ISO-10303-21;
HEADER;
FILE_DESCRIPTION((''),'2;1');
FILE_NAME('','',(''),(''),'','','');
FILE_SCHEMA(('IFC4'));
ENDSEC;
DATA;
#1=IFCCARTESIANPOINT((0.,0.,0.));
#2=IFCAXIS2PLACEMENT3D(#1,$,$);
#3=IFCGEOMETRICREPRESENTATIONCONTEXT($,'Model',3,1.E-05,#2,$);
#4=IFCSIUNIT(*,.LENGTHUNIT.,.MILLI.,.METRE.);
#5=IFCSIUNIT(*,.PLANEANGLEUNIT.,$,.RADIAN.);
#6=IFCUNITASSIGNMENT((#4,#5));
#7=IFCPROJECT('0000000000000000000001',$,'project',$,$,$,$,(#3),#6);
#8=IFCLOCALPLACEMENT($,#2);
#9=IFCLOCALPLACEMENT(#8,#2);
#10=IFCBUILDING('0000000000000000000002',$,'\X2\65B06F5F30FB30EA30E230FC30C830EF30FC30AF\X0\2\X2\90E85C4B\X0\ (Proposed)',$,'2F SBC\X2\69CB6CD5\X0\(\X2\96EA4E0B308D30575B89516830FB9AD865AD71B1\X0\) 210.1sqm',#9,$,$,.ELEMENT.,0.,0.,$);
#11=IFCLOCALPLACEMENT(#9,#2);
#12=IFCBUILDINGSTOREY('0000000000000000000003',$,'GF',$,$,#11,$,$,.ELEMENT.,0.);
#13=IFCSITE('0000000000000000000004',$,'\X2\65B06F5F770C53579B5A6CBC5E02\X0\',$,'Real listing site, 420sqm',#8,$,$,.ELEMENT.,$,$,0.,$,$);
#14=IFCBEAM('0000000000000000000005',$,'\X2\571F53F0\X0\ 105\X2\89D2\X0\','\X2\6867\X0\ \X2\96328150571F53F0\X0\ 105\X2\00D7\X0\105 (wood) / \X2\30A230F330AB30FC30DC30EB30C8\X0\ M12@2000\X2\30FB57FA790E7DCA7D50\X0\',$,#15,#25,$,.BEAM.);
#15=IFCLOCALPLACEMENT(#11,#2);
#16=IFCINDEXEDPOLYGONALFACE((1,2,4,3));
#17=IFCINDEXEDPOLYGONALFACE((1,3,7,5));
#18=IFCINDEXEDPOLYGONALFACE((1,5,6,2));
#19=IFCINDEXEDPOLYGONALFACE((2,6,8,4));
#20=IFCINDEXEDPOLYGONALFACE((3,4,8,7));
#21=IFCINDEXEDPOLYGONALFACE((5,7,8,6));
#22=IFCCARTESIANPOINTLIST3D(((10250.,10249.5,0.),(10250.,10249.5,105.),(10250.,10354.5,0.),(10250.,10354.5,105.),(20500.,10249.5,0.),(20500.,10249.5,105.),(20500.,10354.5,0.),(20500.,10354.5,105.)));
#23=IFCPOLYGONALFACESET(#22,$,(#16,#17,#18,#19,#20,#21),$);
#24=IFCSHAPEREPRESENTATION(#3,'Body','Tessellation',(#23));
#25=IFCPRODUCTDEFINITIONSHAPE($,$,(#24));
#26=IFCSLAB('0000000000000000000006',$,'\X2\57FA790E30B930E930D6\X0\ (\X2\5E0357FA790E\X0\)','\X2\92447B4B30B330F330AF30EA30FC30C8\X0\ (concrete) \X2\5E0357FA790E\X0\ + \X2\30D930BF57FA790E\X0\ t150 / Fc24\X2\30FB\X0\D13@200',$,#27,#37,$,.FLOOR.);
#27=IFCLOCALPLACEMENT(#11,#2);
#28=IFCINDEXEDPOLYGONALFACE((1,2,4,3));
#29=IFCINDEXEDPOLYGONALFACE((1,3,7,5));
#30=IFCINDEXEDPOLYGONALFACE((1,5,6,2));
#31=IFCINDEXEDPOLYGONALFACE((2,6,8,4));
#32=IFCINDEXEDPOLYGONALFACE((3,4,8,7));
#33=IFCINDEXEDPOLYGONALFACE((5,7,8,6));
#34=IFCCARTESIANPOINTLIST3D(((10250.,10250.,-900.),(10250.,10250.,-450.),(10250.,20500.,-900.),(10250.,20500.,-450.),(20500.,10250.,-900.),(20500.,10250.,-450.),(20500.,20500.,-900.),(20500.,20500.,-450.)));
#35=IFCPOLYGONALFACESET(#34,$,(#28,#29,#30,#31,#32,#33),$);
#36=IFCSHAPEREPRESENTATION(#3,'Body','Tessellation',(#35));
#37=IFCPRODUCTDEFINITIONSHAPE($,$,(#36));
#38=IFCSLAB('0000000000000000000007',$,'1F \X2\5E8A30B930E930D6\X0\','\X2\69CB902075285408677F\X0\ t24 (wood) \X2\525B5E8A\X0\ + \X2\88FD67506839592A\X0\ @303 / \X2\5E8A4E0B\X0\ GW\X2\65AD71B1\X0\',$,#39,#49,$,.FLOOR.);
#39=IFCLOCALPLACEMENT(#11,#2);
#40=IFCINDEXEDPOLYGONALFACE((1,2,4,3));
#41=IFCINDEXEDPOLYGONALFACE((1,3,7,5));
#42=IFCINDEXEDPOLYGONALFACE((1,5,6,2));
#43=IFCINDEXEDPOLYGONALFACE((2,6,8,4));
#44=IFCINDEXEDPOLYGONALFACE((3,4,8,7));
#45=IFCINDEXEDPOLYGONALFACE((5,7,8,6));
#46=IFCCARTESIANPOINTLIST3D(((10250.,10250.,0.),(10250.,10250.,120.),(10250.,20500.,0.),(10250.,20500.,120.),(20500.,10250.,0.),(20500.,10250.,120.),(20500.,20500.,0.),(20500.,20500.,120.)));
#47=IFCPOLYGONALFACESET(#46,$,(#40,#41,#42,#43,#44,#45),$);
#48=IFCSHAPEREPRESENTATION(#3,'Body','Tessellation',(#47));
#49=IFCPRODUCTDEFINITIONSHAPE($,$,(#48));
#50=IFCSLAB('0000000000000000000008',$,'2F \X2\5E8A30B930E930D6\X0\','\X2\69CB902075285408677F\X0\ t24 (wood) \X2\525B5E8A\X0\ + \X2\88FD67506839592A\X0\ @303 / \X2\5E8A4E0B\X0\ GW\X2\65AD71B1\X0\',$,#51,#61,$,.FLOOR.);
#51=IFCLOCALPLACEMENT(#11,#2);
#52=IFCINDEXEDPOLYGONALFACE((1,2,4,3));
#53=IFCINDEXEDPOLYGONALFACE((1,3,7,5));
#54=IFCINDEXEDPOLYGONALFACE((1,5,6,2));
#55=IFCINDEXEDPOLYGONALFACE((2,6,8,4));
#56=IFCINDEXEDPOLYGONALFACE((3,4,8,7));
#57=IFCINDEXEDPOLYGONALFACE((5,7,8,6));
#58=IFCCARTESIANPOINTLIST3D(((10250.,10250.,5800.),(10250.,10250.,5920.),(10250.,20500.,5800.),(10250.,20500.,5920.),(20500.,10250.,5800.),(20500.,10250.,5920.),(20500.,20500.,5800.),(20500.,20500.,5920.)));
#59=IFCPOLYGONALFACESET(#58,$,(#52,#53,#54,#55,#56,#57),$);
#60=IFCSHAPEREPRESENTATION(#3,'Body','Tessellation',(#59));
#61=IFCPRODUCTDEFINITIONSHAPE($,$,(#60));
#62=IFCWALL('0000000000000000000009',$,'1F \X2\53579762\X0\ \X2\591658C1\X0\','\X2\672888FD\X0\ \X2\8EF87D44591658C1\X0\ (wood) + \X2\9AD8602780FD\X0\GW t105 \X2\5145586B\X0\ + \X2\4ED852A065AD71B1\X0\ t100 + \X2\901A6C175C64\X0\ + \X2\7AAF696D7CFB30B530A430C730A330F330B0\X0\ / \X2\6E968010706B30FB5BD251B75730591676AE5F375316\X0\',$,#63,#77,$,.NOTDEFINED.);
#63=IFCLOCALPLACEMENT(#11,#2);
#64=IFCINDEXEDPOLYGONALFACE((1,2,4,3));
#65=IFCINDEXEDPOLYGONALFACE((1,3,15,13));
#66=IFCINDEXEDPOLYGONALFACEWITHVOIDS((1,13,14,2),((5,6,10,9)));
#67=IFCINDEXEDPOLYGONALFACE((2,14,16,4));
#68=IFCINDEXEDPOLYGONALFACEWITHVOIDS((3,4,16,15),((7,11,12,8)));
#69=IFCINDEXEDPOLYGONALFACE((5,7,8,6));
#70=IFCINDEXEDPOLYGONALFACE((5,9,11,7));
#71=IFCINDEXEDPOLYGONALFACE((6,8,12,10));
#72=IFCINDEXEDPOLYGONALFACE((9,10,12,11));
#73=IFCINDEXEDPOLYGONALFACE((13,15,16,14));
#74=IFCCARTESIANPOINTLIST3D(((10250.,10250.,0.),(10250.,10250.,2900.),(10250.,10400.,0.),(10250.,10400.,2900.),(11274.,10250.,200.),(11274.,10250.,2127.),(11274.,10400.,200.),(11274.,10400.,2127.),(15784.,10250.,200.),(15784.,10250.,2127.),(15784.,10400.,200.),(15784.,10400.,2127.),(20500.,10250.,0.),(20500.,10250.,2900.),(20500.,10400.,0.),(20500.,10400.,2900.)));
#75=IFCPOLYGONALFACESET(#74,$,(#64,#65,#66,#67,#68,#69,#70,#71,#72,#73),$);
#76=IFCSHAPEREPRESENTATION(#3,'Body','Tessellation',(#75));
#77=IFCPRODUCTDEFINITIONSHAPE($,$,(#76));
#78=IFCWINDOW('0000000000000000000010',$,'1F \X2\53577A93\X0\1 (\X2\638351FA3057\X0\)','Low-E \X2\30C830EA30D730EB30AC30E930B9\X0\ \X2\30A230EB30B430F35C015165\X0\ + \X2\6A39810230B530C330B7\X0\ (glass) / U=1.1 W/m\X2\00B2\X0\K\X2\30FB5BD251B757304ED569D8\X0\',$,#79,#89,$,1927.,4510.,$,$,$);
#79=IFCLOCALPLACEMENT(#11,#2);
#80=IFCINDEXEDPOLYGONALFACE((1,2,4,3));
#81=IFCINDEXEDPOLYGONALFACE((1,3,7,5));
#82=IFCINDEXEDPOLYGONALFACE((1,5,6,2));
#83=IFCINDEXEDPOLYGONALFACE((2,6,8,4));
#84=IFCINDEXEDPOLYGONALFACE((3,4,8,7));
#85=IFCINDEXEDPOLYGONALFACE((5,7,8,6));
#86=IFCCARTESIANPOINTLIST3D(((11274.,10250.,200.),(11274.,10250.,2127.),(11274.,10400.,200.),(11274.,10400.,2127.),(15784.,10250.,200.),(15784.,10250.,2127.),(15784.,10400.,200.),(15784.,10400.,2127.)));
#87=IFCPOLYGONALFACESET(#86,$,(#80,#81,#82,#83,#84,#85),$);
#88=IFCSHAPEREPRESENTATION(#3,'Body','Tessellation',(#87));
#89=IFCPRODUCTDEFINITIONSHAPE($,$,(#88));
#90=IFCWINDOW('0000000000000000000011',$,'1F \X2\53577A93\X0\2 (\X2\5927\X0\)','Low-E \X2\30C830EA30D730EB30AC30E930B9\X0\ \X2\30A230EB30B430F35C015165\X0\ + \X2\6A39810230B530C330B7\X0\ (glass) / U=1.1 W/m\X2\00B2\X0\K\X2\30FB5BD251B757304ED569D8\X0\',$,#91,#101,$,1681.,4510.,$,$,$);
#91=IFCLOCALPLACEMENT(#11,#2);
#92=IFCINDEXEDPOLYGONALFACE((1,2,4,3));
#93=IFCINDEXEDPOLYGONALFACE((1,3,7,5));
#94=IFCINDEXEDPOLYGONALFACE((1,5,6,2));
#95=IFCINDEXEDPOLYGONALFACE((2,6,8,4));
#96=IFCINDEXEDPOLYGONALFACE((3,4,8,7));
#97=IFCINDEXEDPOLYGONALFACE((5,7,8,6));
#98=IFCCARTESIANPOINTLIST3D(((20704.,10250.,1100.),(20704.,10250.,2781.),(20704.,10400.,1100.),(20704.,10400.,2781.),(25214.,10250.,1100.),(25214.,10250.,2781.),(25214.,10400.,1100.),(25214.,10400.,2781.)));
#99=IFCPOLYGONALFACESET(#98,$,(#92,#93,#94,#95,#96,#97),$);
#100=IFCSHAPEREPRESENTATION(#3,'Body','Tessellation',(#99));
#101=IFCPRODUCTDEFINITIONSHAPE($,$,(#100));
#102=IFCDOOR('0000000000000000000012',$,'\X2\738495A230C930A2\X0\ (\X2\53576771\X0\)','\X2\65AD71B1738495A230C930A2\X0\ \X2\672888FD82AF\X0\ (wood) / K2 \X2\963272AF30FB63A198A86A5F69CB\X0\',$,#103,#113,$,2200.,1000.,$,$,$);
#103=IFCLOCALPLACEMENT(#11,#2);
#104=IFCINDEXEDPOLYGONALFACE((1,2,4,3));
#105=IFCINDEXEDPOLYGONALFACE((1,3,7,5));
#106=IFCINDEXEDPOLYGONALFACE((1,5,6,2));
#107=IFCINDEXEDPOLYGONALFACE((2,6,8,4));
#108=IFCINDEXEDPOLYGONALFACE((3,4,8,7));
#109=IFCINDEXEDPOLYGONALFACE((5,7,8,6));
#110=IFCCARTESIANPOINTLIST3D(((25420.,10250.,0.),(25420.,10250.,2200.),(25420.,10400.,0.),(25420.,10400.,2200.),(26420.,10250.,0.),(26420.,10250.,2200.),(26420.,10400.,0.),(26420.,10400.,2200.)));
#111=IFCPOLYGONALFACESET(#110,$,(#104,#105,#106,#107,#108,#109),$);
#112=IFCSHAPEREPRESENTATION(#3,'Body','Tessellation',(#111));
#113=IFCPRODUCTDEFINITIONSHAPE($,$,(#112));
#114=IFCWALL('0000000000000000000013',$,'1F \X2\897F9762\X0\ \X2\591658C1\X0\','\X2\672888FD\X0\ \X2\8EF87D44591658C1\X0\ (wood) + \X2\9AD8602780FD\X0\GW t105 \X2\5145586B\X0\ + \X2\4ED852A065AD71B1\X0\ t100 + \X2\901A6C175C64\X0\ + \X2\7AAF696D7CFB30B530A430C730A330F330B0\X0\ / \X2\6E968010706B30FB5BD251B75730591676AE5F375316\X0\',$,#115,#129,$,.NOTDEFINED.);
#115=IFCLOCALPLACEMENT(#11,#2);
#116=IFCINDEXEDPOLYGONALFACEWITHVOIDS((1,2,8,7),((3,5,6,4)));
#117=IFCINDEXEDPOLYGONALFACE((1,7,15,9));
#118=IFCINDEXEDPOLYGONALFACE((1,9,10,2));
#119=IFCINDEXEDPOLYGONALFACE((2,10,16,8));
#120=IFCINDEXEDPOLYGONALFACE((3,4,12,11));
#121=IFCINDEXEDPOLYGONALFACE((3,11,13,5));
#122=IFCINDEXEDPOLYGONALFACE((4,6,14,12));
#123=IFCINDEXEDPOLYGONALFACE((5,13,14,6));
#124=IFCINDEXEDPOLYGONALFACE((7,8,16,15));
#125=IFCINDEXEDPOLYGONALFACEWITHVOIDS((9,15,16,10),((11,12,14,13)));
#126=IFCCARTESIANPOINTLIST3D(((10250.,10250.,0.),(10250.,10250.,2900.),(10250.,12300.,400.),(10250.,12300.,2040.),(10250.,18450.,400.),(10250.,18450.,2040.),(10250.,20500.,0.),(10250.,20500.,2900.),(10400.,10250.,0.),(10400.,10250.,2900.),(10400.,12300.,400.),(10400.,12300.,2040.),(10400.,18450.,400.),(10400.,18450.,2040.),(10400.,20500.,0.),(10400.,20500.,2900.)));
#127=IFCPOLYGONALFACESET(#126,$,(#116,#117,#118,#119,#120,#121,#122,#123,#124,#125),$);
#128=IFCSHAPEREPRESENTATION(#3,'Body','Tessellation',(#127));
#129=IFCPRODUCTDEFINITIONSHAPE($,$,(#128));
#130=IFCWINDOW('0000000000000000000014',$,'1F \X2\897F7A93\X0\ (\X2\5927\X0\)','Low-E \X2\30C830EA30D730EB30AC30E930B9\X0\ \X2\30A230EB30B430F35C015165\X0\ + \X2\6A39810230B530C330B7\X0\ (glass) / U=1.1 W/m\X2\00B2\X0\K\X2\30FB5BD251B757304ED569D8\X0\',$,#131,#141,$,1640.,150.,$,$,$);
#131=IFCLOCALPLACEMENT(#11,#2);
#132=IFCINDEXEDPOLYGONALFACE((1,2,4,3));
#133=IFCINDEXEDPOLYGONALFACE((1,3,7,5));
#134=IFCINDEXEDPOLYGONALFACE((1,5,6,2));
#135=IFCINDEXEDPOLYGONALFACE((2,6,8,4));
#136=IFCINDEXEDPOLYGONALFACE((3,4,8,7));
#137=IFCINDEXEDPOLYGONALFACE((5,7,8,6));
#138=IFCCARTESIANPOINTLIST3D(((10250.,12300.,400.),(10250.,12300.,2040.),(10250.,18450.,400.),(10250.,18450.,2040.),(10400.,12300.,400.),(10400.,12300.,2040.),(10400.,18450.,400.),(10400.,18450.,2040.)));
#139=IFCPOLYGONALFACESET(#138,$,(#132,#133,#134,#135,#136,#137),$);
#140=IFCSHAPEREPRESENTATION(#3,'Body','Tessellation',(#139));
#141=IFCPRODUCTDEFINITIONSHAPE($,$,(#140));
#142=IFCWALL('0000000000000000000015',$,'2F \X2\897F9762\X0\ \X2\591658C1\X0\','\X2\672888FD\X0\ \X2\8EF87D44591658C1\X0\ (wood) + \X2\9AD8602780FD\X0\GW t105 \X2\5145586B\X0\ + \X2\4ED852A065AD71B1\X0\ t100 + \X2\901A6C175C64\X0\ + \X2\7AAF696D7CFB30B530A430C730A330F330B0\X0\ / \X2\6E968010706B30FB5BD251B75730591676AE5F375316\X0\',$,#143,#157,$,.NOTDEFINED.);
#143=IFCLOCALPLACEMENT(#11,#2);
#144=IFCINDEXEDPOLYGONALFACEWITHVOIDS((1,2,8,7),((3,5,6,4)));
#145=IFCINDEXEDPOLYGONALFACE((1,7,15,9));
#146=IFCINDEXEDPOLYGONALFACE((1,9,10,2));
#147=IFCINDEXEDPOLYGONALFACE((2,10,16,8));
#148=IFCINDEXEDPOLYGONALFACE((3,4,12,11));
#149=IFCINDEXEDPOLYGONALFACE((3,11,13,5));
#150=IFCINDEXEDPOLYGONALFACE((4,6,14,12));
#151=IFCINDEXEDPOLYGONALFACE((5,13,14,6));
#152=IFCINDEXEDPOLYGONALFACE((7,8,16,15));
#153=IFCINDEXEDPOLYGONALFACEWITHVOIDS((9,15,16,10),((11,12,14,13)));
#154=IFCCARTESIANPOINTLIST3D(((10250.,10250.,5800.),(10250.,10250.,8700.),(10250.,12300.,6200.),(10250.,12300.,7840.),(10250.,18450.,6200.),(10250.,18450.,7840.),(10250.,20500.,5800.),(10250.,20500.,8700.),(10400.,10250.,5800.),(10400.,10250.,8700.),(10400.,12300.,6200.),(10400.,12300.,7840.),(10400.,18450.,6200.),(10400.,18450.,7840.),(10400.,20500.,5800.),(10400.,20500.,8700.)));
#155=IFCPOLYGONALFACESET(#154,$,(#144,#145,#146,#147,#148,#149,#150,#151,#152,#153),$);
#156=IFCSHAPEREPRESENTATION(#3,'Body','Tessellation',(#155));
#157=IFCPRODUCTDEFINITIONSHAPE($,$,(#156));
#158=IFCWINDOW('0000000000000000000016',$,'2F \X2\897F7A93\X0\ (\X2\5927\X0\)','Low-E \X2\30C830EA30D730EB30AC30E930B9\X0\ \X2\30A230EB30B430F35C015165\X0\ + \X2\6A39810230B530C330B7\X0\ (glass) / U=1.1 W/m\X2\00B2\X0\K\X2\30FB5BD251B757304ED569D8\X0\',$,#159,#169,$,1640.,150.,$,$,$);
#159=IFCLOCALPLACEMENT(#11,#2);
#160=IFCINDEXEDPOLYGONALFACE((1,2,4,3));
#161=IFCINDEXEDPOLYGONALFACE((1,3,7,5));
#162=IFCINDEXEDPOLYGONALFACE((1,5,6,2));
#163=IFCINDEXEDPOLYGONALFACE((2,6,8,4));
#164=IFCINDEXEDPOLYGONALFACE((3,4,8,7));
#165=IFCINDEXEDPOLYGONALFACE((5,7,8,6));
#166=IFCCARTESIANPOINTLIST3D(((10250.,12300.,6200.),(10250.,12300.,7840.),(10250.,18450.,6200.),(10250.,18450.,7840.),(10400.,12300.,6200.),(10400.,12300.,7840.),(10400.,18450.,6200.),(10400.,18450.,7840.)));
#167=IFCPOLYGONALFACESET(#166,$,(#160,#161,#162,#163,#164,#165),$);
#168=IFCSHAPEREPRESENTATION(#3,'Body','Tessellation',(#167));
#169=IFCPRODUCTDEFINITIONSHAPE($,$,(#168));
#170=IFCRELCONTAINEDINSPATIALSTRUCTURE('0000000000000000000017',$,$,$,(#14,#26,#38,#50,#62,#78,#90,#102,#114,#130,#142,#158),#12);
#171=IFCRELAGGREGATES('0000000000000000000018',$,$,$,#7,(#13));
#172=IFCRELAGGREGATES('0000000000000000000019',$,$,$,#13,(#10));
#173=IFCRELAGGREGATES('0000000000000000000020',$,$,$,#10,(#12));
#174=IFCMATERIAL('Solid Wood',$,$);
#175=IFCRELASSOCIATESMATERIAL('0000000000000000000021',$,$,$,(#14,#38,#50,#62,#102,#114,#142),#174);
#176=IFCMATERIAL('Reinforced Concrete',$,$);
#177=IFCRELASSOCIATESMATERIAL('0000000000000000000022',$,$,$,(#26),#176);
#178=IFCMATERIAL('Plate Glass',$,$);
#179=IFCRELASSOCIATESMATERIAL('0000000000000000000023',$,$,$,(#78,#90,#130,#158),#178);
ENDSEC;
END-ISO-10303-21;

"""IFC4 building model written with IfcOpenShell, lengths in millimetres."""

from ifc_helpers import new_model, si_unit, frame, frame_2d, origin, place, context, project, spatial, rectangle, extrude, material, element, fill, save


model = new_model("IFC4")

# Units and contexts
model_context = context("Model", 3, precision=1e-05, world=origin())
ifc_project = project(units=[si_unit("LENGTHUNIT", "METRE", prefix="MILLI"), si_unit("PLANEANGLEUNIT", "RADIAN")], contexts=[model_context])

# Site, building, storey
site_placement = place(None, origin())
site = spatial("IfcSite", under=ifc_project, at=site_placement, Name="新潟県南魚沼市", ObjectType="Real listing site, 420sqm", CompositionType="ELEMENT", RefElevation=0.0)
building_placement = place(site_placement, origin())
building = spatial("IfcBuilding", under=site, at=building_placement, Name="新潟・リモートワーク2部屋 (Proposed)", ObjectType="2F SBC構法(雪下ろし安全・高断熱) 210.1sqm", CompositionType="ELEMENT", ElevationOfRefHeight=0.0, ElevationOfTerrain=0.0)
storey_placement = place(building_placement, origin())
storey = spatial("IfcBuildingStorey", under=building, at=storey_placement, Name="GF", CompositionType="ELEMENT", Elevation=0.0)

# Shared definitions
ifc_material_1 = material(Name="Solid Wood")

# Beam
beam_placement = place(storey_placement, frame((5125.0, 5125.0, 0.0)))
element("IfcBeam", 1, at=beam_placement, inside=storey, material=ifc_material_1, Name="土台 105角", Description="桧 防腐土台 105×105 (wood) / アンカーボルト M12@2000・基礎緊結", PredefinedType="BEAM", context=model_context, shape_type="SweptSolid", body=[
    extrude(rectangle(XDim=10250.0, YDim=105.0, at=frame_2d((5125.0, 52.0))), frame((5125.0, 5125.0, 0.0)), (0.0, 0.0, 1.0), 105.0),
])

# Slabs
ifc_material_2 = material(Name="Reinforced Concrete")
slab_1_placement = place(storey_placement, frame((5125.0, 5125.0, -450.0)))
element("IfcSlab", 2, at=slab_1_placement, inside=storey, material=ifc_material_2, Name="基礎スラブ (布基礎)", Description="鉄筋コンクリート (concrete) 布基礎 + ベタ基礎 t150 / Fc24・D13@200", PredefinedType="FLOOR", context=model_context, shape_type="SweptSolid", body=[
    extrude(rectangle(XDim=10250.0, YDim=10250.0, at=frame_2d((5125.0, 5125.0))), frame((5125.0, 5125.0, -450.0)), (0.0, 0.0, 1.0), 450.0),
])
slab_2_placement = place(storey_placement, frame((5125.0, 5125.0, 0.0)))
element("IfcSlab", 3, at=slab_2_placement, inside=storey, material=ifc_material_1, Name="1F 床スラブ", Description="構造用合板 t24 (wood) 剛床 + 製材根太 @303 / 床下 GW断熱", PredefinedType="FLOOR", context=model_context, shape_type="SweptSolid", body=[
    extrude(rectangle(XDim=10250.0, YDim=10250.0, at=frame_2d((5125.0, 5125.0))), frame((5125.0, 5125.0, 0.0)), (0.0, 0.0, 1.0), 120.0),
])
slab_3_placement = place(storey_placement, frame((5125.0, 5125.0, 2900.0)))
element("IfcSlab", 4, at=slab_3_placement, inside=storey, material=ifc_material_1, Name="2F 床スラブ", Description="構造用合板 t24 (wood) 剛床 + 製材根太 @303 / 床下 GW断熱", PredefinedType="FLOOR", context=model_context, shape_type="SweptSolid", body=[
    extrude(rectangle(XDim=10250.0, YDim=10250.0, at=frame_2d((5125.0, 5125.0))), frame((5125.0, 5125.0, 2900.0)), (0.0, 0.0, 1.0), 120.0),
])

# Wall, openings, windows, door
wall_1_placement = place(storey_placement, frame((5125.0, 5125.0, 0.0)))
wall_1 = element("IfcWall", 5, at=wall_1_placement, inside=storey, material=ifc_material_1, Name="1F 南面 外壁", Description="木製 軸組外壁 (wood) + 高性能GW t105 充填 + 付加断熱 t100 + 通気層 + 窯業系サイディング / 準耐火・寒冷地外皮強化", PredefinedType="NOTDEFINED", context=model_context, shape_type="SweptSolid", body=[
    extrude(rectangle(XDim=10250.0, YDim=150.0, at=frame_2d((5125.0, 75.0))), frame((5125.0, 5125.0, 0.0)), (0.0, 0.0, 1.0), 2900.0),
])
opening_1_placement = place(storey_placement, frame((5637.0, 5125.0, 100.0)))
opening_1 = element("IfcOpeningElement", 6, at=opening_1_placement, cuts=wall_1, PredefinedType="NOTDEFINED", context=model_context, shape_type="SweptSolid", body=[
    extrude(rectangle(XDim=4510.0, YDim=150.0, at=frame_2d((2255.0, 75.0))), frame((5637.0, 5125.0, 100.0)), (0.0, 0.0, 1.0), 1927.0),
])
opening_2_placement = place(storey_placement, frame((10352.0, 5125.0, 550.0)))
opening_2 = element("IfcOpeningElement", 7, at=opening_2_placement, cuts=wall_1, PredefinedType="NOTDEFINED", context=model_context, shape_type="SweptSolid", body=[
    extrude(rectangle(XDim=4510.0, YDim=150.0, at=frame_2d((2255.0, 75.0))), frame((10352.0, 5125.0, 550.0)), (0.0, 0.0, 1.0), 1681.0),
])
opening_3_placement = place(storey_placement, frame((12710.0, 5125.0, 0.0)))
opening_3 = element("IfcOpeningElement", 8, at=opening_3_placement, cuts=wall_1, PredefinedType="NOTDEFINED", context=model_context, shape_type="SweptSolid", body=[
    extrude(rectangle(XDim=1000.0, YDim=150.0, at=frame_2d((500.0, 75.0))), frame((12710.0, 5125.0, 0.0)), (0.0, 0.0, 1.0), 2200.0),
])
ifc_material_3 = material(Name="Plate Glass")
window_1_placement = place(storey_placement, frame((5637.0, 5125.0, 100.0)))
window_1 = element("IfcWindow", 9, at=window_1_placement, inside=storey, material=ifc_material_3, Name="1F 南窓1 (掃出し)", Description="Low-E トリプルガラス アルゴン封入 + 樹脂サッシ (glass) / U=1.1 W/m²K・寒冷地仕様", OverallHeight=1927.0, OverallWidth=4510.0, context=model_context, shape_type="SweptSolid", body=[
    extrude(rectangle(XDim=4510.0, YDim=150.0, at=frame_2d((2255.0, 75.0))), frame((5637.0, 5125.0, 100.0)), (0.0, 0.0, 1.0), 1927.0),
])
fill(opening_1, window_1)
window_2_placement = place(storey_placement, frame((10352.0, 5125.0, 550.0)))
window_2 = element("IfcWindow", 10, at=window_2_placement, inside=storey, material=ifc_material_3, Name="1F 南窓2 (大)", Description="Low-E トリプルガラス アルゴン封入 + 樹脂サッシ (glass) / U=1.1 W/m²K・寒冷地仕様", OverallHeight=1681.0, OverallWidth=4510.0, context=model_context, shape_type="SweptSolid", body=[
    extrude(rectangle(XDim=4510.0, YDim=150.0, at=frame_2d((2255.0, 75.0))), frame((10352.0, 5125.0, 550.0)), (0.0, 0.0, 1.0), 1681.0),
])
fill(opening_2, window_2)
door_placement = place(storey_placement, frame((12710.0, 5125.0, 0.0)))
door = element("IfcDoor", 11, at=door_placement, inside=storey, material=ifc_material_1, Name="玄関ドア (南東)", Description="断熱玄関ドア 木製芯 (wood) / K2 防犯・採風機構", OverallHeight=2200.0, OverallWidth=1000.0, context=model_context, shape_type="SweptSolid", body=[
    extrude(rectangle(XDim=1000.0, YDim=150.0, at=frame_2d((500.0, 75.0))), frame((12710.0, 5125.0, 0.0)), (0.0, 0.0, 1.0), 2200.0),
])
fill(opening_3, door)

# Wall, opening, window
wall_2_placement = place(storey_placement, frame((5125.0, 5125.0, 0.0)))
wall_2 = element("IfcWall", 12, at=wall_2_placement, inside=storey, material=ifc_material_1, Name="1F 西面 外壁", Description="木製 軸組外壁 (wood) + 高性能GW t105 充填 + 付加断熱 t100 + 通気層 + 窯業系サイディング / 準耐火・寒冷地外皮強化", PredefinedType="NOTDEFINED", context=model_context, shape_type="SweptSolid", body=[
    extrude(rectangle(XDim=150.0, YDim=10250.0, at=frame_2d((75.0, 5125.0))), frame((5125.0, 5125.0, 0.0)), (0.0, 0.0, 1.0), 2900.0),
])
opening_4_placement = place(storey_placement, frame((5125.0, 6150.0, 200.0)))
opening_4 = element("IfcOpeningElement", 13, at=opening_4_placement, cuts=wall_2, PredefinedType="NOTDEFINED", context=model_context, shape_type="SweptSolid", body=[
    extrude(rectangle(XDim=150.0, YDim=6150.0, at=frame_2d((75.0, 3075.0))), frame((5125.0, 6150.0, 200.0)), (0.0, 0.0, 1.0), 1640.0),
])
window_3_placement = place(storey_placement, frame((5125.0, 6150.0, 200.0)))
window_3 = element("IfcWindow", 14, at=window_3_placement, inside=storey, material=ifc_material_3, Name="1F 西窓 (大)", Description="Low-E トリプルガラス アルゴン封入 + 樹脂サッシ (glass) / U=1.1 W/m²K・寒冷地仕様", OverallHeight=1640.0, OverallWidth=150.0, context=model_context, shape_type="SweptSolid", body=[
    extrude(rectangle(XDim=150.0, YDim=6150.0, at=frame_2d((75.0, 3075.0))), frame((5125.0, 6150.0, 200.0)), (0.0, 0.0, 1.0), 1640.0),
])
fill(opening_4, window_3)

# Wall, opening, window
wall_3_placement = place(storey_placement, frame((5125.0, 5125.0, 2900.0)))
wall_3 = element("IfcWall", 15, at=wall_3_placement, inside=storey, material=ifc_material_1, Name="2F 西面 外壁", Description="木製 軸組外壁 (wood) + 高性能GW t105 充填 + 付加断熱 t100 + 通気層 + 窯業系サイディング / 準耐火・寒冷地外皮強化", PredefinedType="NOTDEFINED", context=model_context, shape_type="SweptSolid", body=[
    extrude(rectangle(XDim=150.0, YDim=10250.0, at=frame_2d((75.0, 5125.0))), frame((5125.0, 5125.0, 2900.0)), (0.0, 0.0, 1.0), 2900.0),
])
opening_5_placement = place(storey_placement, frame((5125.0, 6150.0, 3100.0)))
opening_5 = element("IfcOpeningElement", 16, at=opening_5_placement, cuts=wall_3, PredefinedType="NOTDEFINED", context=model_context, shape_type="SweptSolid", body=[
    extrude(rectangle(XDim=150.0, YDim=6150.0, at=frame_2d((75.0, 3075.0))), frame((5125.0, 6150.0, 3100.0)), (0.0, 0.0, 1.0), 1640.0),
])
window_4_placement = place(storey_placement, frame((5125.0, 6150.0, 3100.0)))
window_4 = element("IfcWindow", 17, at=window_4_placement, inside=storey, material=ifc_material_3, Name="2F 西窓 (大)", Description="Low-E トリプルガラス アルゴン封入 + 樹脂サッシ (glass) / U=1.1 W/m²K・寒冷地仕様", OverallHeight=1640.0, OverallWidth=150.0, context=model_context, shape_type="SweptSolid", body=[
    extrude(rectangle(XDim=150.0, YDim=6150.0, at=frame_2d((75.0, 3075.0))), frame((5125.0, 6150.0, 3100.0)), (0.0, 0.0, 1.0), 1640.0),
])
fill(opening_5, window_4)

save(model, "model.ifc")
